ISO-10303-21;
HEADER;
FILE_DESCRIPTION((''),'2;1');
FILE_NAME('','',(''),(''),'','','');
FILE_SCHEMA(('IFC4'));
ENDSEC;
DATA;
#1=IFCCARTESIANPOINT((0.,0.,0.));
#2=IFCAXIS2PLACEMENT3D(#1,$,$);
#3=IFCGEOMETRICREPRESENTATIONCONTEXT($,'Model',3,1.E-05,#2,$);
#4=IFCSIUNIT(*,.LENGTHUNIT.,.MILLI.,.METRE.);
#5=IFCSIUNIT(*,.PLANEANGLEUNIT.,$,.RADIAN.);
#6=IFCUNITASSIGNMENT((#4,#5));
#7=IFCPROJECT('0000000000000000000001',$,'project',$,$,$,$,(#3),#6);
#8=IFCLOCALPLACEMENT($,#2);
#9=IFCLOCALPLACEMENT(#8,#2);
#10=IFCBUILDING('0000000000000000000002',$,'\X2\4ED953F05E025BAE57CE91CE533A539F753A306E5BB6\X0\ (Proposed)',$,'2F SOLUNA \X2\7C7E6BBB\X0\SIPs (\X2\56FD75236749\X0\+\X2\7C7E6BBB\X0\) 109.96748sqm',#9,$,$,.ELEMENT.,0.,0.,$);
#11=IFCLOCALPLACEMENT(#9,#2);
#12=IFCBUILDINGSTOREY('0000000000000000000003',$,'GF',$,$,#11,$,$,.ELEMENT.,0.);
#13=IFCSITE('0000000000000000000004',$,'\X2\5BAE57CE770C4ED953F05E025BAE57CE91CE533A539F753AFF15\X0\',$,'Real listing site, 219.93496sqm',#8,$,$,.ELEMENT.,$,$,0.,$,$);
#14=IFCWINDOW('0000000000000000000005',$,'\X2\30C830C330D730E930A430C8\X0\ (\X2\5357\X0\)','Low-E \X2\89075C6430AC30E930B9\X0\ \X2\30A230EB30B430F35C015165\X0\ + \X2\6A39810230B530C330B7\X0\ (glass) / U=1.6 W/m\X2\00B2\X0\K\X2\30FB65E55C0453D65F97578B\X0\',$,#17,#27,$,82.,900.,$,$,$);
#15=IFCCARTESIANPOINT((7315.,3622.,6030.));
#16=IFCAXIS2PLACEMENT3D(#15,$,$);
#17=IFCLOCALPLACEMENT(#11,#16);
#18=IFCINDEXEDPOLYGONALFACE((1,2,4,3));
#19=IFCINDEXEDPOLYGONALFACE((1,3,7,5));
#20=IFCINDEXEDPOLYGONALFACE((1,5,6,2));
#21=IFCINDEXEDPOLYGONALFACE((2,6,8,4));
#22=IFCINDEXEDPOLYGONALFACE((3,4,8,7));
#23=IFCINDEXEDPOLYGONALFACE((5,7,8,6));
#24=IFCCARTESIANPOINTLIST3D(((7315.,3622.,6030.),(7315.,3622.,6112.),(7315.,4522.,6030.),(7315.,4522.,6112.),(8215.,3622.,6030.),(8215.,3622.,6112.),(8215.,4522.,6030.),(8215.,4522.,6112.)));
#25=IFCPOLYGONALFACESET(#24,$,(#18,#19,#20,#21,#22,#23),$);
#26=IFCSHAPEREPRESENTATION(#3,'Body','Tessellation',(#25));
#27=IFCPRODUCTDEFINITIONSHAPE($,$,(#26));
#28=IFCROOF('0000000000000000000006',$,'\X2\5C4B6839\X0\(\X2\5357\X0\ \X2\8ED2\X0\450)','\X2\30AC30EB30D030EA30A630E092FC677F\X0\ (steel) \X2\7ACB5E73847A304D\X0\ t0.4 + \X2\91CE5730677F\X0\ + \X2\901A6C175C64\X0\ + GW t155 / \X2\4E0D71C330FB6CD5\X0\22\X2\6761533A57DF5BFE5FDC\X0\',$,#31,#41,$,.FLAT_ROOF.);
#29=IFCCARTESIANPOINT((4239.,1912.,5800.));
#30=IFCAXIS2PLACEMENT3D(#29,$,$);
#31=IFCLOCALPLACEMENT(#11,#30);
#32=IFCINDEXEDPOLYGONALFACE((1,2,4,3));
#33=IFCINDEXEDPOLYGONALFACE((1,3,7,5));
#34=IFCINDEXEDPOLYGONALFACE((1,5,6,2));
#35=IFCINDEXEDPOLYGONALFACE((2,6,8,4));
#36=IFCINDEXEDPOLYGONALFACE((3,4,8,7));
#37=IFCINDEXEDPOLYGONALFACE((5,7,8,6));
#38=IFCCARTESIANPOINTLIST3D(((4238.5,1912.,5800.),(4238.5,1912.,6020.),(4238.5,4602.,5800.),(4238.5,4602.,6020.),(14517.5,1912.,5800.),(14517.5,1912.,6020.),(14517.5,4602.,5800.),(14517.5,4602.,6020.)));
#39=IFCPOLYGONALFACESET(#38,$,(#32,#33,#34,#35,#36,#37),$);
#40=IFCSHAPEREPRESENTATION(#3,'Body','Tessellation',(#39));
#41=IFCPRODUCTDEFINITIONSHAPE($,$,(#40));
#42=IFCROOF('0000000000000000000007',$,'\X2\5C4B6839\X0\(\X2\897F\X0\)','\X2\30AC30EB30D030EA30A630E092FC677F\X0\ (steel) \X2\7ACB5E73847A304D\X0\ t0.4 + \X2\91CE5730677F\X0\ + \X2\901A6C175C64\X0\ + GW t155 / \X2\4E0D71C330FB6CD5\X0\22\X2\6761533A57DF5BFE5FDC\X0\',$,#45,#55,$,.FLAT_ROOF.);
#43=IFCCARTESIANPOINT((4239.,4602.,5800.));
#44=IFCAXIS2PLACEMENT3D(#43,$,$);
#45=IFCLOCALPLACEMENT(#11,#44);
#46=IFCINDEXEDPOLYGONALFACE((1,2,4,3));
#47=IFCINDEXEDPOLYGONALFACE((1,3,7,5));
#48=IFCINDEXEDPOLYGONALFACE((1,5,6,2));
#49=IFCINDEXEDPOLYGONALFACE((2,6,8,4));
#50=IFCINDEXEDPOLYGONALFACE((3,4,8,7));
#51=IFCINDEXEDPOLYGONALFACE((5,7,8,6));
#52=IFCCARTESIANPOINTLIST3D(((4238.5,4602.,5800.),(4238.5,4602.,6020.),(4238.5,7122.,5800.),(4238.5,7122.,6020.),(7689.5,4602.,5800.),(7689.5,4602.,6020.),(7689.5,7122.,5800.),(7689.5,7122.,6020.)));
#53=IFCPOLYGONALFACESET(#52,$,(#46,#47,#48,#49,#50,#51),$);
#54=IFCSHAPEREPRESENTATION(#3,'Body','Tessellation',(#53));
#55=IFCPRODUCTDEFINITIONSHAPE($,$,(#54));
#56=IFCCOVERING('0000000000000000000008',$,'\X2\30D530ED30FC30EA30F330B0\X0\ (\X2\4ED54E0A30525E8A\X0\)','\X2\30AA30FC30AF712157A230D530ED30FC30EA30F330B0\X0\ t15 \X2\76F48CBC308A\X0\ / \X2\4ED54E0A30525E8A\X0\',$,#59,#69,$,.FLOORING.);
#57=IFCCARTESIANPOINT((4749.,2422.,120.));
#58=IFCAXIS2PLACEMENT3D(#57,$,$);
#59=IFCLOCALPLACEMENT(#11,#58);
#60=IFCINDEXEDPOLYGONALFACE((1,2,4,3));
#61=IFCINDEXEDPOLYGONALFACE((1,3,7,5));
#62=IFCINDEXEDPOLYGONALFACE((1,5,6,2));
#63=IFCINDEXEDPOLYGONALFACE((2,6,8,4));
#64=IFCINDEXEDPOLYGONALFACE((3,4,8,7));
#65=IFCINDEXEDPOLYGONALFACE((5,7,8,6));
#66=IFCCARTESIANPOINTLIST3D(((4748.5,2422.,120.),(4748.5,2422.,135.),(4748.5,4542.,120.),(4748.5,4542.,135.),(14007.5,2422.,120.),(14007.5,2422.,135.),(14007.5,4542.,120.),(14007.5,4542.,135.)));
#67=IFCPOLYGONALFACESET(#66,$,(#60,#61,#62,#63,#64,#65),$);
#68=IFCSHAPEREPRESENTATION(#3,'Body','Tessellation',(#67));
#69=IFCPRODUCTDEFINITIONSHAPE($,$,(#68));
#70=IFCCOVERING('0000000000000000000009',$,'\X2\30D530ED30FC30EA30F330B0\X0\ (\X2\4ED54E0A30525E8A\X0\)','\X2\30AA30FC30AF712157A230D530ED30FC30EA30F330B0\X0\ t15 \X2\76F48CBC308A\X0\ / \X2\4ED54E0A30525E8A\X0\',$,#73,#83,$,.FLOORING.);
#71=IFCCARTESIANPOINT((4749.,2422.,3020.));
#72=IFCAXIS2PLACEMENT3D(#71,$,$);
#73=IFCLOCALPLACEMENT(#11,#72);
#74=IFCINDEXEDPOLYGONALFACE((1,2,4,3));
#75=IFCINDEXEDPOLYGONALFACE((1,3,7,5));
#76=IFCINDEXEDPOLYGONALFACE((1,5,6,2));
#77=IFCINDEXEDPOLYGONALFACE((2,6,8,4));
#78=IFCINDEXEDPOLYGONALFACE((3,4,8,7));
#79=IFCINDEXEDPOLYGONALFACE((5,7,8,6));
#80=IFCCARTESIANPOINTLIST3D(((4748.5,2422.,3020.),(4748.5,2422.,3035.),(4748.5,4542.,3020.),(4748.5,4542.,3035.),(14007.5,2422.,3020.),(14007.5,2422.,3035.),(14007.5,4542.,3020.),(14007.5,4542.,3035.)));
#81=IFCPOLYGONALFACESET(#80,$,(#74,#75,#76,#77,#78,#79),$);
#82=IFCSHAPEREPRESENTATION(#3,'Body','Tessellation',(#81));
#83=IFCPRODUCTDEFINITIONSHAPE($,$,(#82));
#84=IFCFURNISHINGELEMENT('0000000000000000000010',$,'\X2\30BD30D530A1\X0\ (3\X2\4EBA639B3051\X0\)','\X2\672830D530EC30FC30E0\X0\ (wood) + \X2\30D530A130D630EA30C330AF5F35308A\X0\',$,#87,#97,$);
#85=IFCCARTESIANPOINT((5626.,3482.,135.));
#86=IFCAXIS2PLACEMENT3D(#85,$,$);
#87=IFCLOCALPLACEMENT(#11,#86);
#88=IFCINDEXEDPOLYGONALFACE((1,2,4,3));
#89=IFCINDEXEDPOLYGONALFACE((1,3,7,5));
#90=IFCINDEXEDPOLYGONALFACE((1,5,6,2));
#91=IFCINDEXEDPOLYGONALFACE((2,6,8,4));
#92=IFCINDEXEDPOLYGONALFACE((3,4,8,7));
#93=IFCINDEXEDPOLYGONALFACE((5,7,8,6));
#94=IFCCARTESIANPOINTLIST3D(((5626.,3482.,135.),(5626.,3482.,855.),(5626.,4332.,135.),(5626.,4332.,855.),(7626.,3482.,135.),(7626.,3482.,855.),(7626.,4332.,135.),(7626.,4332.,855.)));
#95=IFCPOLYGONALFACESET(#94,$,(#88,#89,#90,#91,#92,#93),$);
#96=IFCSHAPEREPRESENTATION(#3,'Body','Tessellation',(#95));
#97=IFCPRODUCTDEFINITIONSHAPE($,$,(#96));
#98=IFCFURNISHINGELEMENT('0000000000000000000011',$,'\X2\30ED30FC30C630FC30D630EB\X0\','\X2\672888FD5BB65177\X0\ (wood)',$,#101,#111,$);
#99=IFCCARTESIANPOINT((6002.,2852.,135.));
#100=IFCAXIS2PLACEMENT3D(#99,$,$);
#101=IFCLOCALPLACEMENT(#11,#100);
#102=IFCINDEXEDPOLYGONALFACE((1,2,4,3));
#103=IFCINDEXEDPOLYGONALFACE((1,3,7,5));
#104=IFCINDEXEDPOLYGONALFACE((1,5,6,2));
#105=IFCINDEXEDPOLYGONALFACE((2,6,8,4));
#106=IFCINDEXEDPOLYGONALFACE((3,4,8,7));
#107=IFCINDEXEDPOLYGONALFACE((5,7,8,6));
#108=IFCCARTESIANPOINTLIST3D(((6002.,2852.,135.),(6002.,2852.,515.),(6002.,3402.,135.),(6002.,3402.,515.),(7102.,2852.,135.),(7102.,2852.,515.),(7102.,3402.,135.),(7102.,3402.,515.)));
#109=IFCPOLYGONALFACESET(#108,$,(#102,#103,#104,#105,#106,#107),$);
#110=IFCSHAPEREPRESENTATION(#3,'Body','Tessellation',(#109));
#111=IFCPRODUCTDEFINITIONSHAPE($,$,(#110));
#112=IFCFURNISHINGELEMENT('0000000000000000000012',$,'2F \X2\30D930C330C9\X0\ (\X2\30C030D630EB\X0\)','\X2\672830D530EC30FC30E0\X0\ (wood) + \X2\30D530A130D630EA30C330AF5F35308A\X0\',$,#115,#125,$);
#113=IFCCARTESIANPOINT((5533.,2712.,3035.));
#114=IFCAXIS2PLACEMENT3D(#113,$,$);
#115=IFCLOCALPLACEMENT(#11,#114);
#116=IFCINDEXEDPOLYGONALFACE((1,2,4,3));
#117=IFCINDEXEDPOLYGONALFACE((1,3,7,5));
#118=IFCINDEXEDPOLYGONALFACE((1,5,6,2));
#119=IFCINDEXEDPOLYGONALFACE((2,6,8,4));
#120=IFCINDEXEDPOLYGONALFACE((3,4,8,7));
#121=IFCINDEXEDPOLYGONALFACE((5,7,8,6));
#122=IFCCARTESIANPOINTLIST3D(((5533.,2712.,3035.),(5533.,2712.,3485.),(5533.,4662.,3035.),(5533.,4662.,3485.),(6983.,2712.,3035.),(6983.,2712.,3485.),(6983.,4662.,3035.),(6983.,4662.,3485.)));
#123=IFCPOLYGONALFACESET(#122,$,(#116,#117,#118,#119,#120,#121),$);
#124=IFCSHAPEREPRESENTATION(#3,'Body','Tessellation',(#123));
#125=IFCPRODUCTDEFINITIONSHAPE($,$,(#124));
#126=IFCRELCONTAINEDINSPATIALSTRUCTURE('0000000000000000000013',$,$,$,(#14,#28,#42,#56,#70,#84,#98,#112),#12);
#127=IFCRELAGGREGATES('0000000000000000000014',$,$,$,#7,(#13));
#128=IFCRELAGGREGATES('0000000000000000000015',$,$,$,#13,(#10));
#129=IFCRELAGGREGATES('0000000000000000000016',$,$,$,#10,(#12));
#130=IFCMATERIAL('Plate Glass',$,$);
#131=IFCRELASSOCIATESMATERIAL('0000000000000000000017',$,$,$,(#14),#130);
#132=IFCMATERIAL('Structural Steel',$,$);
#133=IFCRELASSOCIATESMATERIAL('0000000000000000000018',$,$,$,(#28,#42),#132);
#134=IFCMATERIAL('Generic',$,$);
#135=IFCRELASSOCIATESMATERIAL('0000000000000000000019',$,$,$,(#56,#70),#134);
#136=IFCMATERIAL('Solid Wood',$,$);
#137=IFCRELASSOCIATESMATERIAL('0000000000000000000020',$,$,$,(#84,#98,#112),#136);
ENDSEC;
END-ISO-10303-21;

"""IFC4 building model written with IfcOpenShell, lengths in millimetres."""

from ifc_helpers import new_model, si_unit, frame, frame_2d, origin, place, context, project, spatial, rectangle, extrude, material, element, save


model = new_model("IFC4")

# Units and contexts
model_context = context("Model", 3, precision=1e-05, world=origin())
ifc_project = project(units=[si_unit("LENGTHUNIT", "METRE", prefix="MILLI"), si_unit("PLANEANGLEUNIT", "RADIAN")], contexts=[model_context])

# Site, building, storey
site_placement = place(None, origin())
site = spatial("IfcSite", under=ifc_project, at=site_placement, Name="宮城県仙台市宮城野区原町５", ObjectType="Real listing site, 219.93496sqm", CompositionType="ELEMENT", RefElevation=0.0)
building_placement = place(site_placement, origin())
building = spatial("IfcBuilding", under=site, at=building_placement, Name="仙台市宮城野区原町の家 (Proposed)", ObjectType="2F SOLUNA 籾殻SIPs (国産杉+籾殻) 109.96748sqm", CompositionType="ELEMENT", ElevationOfRefHeight=0.0, ElevationOfTerrain=0.0)
storey_placement = place(building_placement, origin())
storey = spatial("IfcBuildingStorey", under=building, at=storey_placement, Name="GF", CompositionType="ELEMENT", Elevation=0.0)

# Shared definitions
ifc_material_1 = material(Name="Solid Wood")

# Shared definitions
ifc_material_2 = material(Name="Plate Glass")

# Window
window_1_placement = place(storey_placement, frame((7315.0, 3622.0, 6030.0)))
element("IfcWindow", 1, at=window_1_placement, inside=storey, material=ifc_material_2, Name="トップライト (南)", Description="Low-E 複層ガラス アルゴン封入 + 樹脂サッシ (glass) / U=1.6 W/m²K・日射取得型", OverallHeight=82.0, OverallWidth=900.0, context=model_context, shape_type="SweptSolid", body=[
    extrude(rectangle(XDim=900.0, YDim=900.0, at=frame_2d((450.0, 450.0))), frame((7315.0, 3622.0, 6030.0)), (0.0, 0.0, 1.0), 82.0),
])

# Roofs
ifc_material_3 = material(Name="Structural Steel")
roof_1_placement = place(storey_placement, frame((4239.0, 1912.0, 5800.0)))
element("IfcRoof", 2, at=roof_1_placement, inside=storey, material=ifc_material_3, Name="屋根(南 軒450)", Description="ガルバリウム鋼板 (steel) 立平葺き t0.4 + 野地板 + 通気層 + GW t155 / 不燃・法22条区域対応", PredefinedType="FLAT_ROOF", context=model_context, shape_type="SweptSolid", body=[
    extrude(rectangle(XDim=10279.0, YDim=2690.0, at=frame_2d((5139.0, 1345.0))), frame((4239.0, 1912.0, 5800.0)), (0.0, 0.0, 1.0), 220.0),
])
roof_2_placement = place(storey_placement, frame((4239.0, 4602.0, 5800.0)))
element("IfcRoof", 3, at=roof_2_placement, inside=storey, material=ifc_material_3, Name="屋根(西)", Description="ガルバリウム鋼板 (steel) 立平葺き t0.4 + 野地板 + 通気層 + GW t155 / 不燃・法22条区域対応", PredefinedType="FLAT_ROOF", context=model_context, shape_type="SweptSolid", body=[
    extrude(rectangle(XDim=3451.0, YDim=2520.0, at=frame_2d((1725.0, 1260.0))), frame((4239.0, 4602.0, 5800.0)), (0.0, 0.0, 1.0), 220.0),
])

# Coverings
ifc_material_4 = material(Name="Generic")
covering_1_placement = place(storey_placement, frame((4749.0, 2422.0, 120.0)))
element("IfcCovering", 4, at=covering_1_placement, inside=storey, material=ifc_material_4, Name="フローリング (仕上げ床)", Description="オーク無垢フローリング t15 直貼り / 仕上げ床", PredefinedType="FLOORING", context=model_context, shape_type="SweptSolid", body=[
    extrude(rectangle(XDim=9259.0, YDim=2120.0, at=frame_2d((4629.0, 1060.0))), frame((4749.0, 2422.0, 120.0)), (0.0, 0.0, 1.0), 15.0),
])
covering_2_placement = place(storey_placement, frame((4749.0, 2422.0, 3020.0)))
element("IfcCovering", 5, at=covering_2_placement, inside=storey, material=ifc_material_4, Name="フローリング (仕上げ床)", Description="オーク無垢フローリング t15 直貼り / 仕上げ床", PredefinedType="FLOORING", context=model_context, shape_type="SweptSolid", body=[
    extrude(rectangle(XDim=9259.0, YDim=2120.0, at=frame_2d((4629.0, 1060.0))), frame((4749.0, 2422.0, 3020.0)), (0.0, 0.0, 1.0), 15.0),
])

# Furnishing elements
furnishing_1_placement = place(storey_placement, frame((5626.0, 3482.0, 135.0)))
element("IfcFurnishingElement", 6, at=furnishing_1_placement, inside=storey, material=ifc_material_1, Name="ソファ (3人掛け)", Description="木フレーム (wood) + ファブリック張り", context=model_context, shape_type="SweptSolid", body=[
    extrude(rectangle(XDim=2000.0, YDim=850.0, at=frame_2d((1000.0, 425.0))), frame((5626.0, 3482.0, 135.0)), (0.0, 0.0, 1.0), 720.0),
])
furnishing_2_placement = place(storey_placement, frame((6002.0, 2852.0, 135.0)))
element("IfcFurnishingElement", 7, at=furnishing_2_placement, inside=storey, material=ifc_material_1, Name="ローテーブル", Description="木製家具 (wood)", context=model_context, shape_type="SweptSolid", body=[
    extrude(rectangle(XDim=1100.0, YDim=550.0, at=frame_2d((550.0, 275.0))), frame((6002.0, 2852.0, 135.0)), (0.0, 0.0, 1.0), 380.0),
])
furnishing_3_placement = place(storey_placement, frame((5533.0, 2712.0, 3035.0)))
element("IfcFurnishingElement", 8, at=furnishing_3_placement, inside=storey, material=ifc_material_1, Name="2F ベッド (ダブル)", Description="木フレーム (wood) + ファブリック張り", context=model_context, shape_type="SweptSolid", body=[
    extrude(rectangle(XDim=1450.0, YDim=1950.0, at=frame_2d((725.0, 975.0))), frame((5533.0, 2712.0, 3035.0)), (0.0, 0.0, 1.0), 450.0),
])

save(model, "model.ifc")
